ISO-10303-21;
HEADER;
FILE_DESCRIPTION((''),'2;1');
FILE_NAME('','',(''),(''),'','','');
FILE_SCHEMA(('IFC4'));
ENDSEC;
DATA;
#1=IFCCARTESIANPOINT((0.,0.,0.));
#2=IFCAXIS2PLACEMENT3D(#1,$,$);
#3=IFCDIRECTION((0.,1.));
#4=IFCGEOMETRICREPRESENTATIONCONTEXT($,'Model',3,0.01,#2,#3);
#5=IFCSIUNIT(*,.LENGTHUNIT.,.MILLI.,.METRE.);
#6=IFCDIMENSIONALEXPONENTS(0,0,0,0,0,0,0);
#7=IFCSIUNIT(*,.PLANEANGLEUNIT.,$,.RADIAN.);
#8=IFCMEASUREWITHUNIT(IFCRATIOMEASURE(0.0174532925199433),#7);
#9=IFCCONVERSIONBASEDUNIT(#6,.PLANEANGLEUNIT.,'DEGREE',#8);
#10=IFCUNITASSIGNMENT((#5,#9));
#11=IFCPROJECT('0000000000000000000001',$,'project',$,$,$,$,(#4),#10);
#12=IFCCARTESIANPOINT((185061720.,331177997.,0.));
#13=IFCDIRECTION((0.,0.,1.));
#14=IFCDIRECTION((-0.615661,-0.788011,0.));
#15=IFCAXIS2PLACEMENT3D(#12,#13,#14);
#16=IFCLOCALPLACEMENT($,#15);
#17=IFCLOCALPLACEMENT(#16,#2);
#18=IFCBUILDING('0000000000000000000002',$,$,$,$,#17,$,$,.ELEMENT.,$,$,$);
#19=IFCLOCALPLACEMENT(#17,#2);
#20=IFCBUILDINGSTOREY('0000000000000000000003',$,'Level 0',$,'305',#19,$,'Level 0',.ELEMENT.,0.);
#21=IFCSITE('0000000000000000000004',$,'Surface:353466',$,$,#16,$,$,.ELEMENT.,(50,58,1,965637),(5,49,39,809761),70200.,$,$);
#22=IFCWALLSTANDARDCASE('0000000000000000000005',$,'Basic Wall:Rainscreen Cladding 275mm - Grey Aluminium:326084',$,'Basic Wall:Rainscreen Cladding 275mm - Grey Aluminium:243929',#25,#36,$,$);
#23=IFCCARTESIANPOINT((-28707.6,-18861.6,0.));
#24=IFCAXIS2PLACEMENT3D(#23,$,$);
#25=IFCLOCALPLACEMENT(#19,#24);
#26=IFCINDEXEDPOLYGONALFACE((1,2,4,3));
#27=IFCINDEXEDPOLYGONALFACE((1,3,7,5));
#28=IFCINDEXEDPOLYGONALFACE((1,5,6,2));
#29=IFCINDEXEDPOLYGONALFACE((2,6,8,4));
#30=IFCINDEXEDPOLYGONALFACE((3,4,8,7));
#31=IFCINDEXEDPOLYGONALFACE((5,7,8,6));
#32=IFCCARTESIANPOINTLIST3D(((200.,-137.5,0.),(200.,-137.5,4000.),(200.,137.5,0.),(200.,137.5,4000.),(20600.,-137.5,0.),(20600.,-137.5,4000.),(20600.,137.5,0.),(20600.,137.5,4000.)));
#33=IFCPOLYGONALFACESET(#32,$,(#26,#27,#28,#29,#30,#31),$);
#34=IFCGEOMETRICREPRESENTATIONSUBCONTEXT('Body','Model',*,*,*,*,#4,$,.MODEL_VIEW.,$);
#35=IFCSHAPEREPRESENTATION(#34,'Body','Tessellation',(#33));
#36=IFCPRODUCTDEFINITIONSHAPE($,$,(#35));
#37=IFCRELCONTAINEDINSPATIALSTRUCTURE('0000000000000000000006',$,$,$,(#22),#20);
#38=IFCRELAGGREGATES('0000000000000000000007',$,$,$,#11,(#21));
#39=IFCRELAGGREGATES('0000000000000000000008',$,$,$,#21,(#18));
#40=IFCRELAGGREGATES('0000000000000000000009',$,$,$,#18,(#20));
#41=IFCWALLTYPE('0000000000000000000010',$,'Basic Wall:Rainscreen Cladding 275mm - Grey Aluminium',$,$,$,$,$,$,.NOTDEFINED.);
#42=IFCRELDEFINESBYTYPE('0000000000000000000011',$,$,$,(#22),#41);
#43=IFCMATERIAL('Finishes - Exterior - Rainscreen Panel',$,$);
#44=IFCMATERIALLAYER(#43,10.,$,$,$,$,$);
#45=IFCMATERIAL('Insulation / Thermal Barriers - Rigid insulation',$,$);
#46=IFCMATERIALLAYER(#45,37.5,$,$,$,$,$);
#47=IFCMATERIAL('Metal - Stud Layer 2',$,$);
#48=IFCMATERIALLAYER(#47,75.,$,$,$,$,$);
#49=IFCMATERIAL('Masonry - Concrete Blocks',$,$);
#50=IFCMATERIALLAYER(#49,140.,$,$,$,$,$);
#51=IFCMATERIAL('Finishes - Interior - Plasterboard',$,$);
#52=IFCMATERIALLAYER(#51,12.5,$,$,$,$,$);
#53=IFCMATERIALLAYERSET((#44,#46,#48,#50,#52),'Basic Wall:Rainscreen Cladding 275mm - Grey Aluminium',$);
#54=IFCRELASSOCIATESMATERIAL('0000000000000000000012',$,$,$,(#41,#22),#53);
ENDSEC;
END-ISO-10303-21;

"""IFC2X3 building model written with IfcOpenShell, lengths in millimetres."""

from ifc_helpers import new_model, entity, si_unit, converted_unit, direction, frame, frame_2d, origin, place, context, subcontext, project, spatial, rectangle, extrude, clip, halfspace, material, layer, layer_set, layer_usage, type_object, element, save


model = new_model("IFC2X3")

# Units and contexts
model_context = context("Model", 3, precision=0.01, world=origin(), true_north=direction((0.0, 1.0)))
body_context = subcontext(model_context, "Body", "Model", "MODEL_VIEW")
ifc_project = project(units=[si_unit("LENGTHUNIT", "METRE", prefix="MILLI"), converted_unit("PLANEANGLEUNIT", "DEGREE", entity("IfcRatioMeasure", 0.0174532925199433), si_unit("PLANEANGLEUNIT", "RADIAN"), dimensions=[0, 0, 0, 0, 0, 0, 0])], contexts=[model_context])

# Site, building, storey
site_placement = place(None, frame((185061720.0, 331177997.0, 0.0), z_axis=(0.0, 0.0, 1.0), x_axis=(-0.615661, -0.788011, 0.0)))
site = spatial("IfcSite", under=ifc_project, at=site_placement, Name="Surface:353466", CompositionType="ELEMENT", RefLatitude=(50, 58, 1, 965637), RefLongitude=(5, 49, 39, 809761), RefElevation=70200.0)
building_placement = place(site_placement, origin())
building = spatial("IfcBuilding", under=site, at=building_placement, CompositionType="ELEMENT")
storey_placement = place(building_placement, origin())
storey = spatial("IfcBuildingStorey", under=building, at=storey_placement, Name="Level 0", ObjectType="305", LongName="Level 0", CompositionType="ELEMENT", Elevation=0.0)

# Wall
ifc_material_1 = material(Name="Finishes - Exterior - Rainscreen Panel")
ifc_layer_1 = layer(ifc_material_1, 10.0)
ifc_material_2 = material(Name="Insulation / Thermal Barriers - Rigid insulation")
ifc_layer_2 = layer(ifc_material_2, 37.5)
ifc_material_3 = material(Name="Metal - Stud Layer 2")
ifc_layer_3 = layer(ifc_material_3, 75.0)
ifc_material_4 = material(Name="Masonry - Concrete Blocks")
ifc_layer_4 = layer(ifc_material_4, 140.0)
ifc_material_5 = material(Name="Finishes - Interior - Plasterboard")
ifc_layer_5 = layer(ifc_material_5, 12.5)
ifc_layer_set_1 = layer_set([ifc_layer_1, ifc_layer_2, ifc_layer_3, ifc_layer_4, ifc_layer_5], Name="Basic Wall:Rainscreen Cladding 275mm - Grey Aluminium")
ifc_layer_usage_1 = layer_usage(ifc_layer_set_1, "AXIS2", "POSITIVE", -137.5)
wall_type_1 = type_object("IfcWallType", Name="Basic Wall:Rainscreen Cladding 275mm - Grey Aluminium", PredefinedType="NOTDEFINED", material=ifc_layer_set_1)
wall_1_placement = place(storey_placement, frame((-28707.6, -18861.6, 0.0)))
element("IfcWallStandardCase", 1, at=wall_1_placement, inside=storey, type_object=wall_type_1, material=ifc_layer_usage_1, Name="Basic Wall:Rainscreen Cladding 275mm - Grey Aluminium:326084", ObjectType="Basic Wall:Rainscreen Cladding 275mm - Grey Aluminium:243929", context=body_context, shape_type="Clipping", body=[
    clip(extrude(rectangle(XDim=20400.0, YDim=275.0, at=frame_2d((10400.0, 0.0), x_axis=(1.0, 0.0))), origin(), (0.0, 0.0, 1.0), 4000.0), halfspace(origin(), True)),
])

save(model, "model.ifc")
